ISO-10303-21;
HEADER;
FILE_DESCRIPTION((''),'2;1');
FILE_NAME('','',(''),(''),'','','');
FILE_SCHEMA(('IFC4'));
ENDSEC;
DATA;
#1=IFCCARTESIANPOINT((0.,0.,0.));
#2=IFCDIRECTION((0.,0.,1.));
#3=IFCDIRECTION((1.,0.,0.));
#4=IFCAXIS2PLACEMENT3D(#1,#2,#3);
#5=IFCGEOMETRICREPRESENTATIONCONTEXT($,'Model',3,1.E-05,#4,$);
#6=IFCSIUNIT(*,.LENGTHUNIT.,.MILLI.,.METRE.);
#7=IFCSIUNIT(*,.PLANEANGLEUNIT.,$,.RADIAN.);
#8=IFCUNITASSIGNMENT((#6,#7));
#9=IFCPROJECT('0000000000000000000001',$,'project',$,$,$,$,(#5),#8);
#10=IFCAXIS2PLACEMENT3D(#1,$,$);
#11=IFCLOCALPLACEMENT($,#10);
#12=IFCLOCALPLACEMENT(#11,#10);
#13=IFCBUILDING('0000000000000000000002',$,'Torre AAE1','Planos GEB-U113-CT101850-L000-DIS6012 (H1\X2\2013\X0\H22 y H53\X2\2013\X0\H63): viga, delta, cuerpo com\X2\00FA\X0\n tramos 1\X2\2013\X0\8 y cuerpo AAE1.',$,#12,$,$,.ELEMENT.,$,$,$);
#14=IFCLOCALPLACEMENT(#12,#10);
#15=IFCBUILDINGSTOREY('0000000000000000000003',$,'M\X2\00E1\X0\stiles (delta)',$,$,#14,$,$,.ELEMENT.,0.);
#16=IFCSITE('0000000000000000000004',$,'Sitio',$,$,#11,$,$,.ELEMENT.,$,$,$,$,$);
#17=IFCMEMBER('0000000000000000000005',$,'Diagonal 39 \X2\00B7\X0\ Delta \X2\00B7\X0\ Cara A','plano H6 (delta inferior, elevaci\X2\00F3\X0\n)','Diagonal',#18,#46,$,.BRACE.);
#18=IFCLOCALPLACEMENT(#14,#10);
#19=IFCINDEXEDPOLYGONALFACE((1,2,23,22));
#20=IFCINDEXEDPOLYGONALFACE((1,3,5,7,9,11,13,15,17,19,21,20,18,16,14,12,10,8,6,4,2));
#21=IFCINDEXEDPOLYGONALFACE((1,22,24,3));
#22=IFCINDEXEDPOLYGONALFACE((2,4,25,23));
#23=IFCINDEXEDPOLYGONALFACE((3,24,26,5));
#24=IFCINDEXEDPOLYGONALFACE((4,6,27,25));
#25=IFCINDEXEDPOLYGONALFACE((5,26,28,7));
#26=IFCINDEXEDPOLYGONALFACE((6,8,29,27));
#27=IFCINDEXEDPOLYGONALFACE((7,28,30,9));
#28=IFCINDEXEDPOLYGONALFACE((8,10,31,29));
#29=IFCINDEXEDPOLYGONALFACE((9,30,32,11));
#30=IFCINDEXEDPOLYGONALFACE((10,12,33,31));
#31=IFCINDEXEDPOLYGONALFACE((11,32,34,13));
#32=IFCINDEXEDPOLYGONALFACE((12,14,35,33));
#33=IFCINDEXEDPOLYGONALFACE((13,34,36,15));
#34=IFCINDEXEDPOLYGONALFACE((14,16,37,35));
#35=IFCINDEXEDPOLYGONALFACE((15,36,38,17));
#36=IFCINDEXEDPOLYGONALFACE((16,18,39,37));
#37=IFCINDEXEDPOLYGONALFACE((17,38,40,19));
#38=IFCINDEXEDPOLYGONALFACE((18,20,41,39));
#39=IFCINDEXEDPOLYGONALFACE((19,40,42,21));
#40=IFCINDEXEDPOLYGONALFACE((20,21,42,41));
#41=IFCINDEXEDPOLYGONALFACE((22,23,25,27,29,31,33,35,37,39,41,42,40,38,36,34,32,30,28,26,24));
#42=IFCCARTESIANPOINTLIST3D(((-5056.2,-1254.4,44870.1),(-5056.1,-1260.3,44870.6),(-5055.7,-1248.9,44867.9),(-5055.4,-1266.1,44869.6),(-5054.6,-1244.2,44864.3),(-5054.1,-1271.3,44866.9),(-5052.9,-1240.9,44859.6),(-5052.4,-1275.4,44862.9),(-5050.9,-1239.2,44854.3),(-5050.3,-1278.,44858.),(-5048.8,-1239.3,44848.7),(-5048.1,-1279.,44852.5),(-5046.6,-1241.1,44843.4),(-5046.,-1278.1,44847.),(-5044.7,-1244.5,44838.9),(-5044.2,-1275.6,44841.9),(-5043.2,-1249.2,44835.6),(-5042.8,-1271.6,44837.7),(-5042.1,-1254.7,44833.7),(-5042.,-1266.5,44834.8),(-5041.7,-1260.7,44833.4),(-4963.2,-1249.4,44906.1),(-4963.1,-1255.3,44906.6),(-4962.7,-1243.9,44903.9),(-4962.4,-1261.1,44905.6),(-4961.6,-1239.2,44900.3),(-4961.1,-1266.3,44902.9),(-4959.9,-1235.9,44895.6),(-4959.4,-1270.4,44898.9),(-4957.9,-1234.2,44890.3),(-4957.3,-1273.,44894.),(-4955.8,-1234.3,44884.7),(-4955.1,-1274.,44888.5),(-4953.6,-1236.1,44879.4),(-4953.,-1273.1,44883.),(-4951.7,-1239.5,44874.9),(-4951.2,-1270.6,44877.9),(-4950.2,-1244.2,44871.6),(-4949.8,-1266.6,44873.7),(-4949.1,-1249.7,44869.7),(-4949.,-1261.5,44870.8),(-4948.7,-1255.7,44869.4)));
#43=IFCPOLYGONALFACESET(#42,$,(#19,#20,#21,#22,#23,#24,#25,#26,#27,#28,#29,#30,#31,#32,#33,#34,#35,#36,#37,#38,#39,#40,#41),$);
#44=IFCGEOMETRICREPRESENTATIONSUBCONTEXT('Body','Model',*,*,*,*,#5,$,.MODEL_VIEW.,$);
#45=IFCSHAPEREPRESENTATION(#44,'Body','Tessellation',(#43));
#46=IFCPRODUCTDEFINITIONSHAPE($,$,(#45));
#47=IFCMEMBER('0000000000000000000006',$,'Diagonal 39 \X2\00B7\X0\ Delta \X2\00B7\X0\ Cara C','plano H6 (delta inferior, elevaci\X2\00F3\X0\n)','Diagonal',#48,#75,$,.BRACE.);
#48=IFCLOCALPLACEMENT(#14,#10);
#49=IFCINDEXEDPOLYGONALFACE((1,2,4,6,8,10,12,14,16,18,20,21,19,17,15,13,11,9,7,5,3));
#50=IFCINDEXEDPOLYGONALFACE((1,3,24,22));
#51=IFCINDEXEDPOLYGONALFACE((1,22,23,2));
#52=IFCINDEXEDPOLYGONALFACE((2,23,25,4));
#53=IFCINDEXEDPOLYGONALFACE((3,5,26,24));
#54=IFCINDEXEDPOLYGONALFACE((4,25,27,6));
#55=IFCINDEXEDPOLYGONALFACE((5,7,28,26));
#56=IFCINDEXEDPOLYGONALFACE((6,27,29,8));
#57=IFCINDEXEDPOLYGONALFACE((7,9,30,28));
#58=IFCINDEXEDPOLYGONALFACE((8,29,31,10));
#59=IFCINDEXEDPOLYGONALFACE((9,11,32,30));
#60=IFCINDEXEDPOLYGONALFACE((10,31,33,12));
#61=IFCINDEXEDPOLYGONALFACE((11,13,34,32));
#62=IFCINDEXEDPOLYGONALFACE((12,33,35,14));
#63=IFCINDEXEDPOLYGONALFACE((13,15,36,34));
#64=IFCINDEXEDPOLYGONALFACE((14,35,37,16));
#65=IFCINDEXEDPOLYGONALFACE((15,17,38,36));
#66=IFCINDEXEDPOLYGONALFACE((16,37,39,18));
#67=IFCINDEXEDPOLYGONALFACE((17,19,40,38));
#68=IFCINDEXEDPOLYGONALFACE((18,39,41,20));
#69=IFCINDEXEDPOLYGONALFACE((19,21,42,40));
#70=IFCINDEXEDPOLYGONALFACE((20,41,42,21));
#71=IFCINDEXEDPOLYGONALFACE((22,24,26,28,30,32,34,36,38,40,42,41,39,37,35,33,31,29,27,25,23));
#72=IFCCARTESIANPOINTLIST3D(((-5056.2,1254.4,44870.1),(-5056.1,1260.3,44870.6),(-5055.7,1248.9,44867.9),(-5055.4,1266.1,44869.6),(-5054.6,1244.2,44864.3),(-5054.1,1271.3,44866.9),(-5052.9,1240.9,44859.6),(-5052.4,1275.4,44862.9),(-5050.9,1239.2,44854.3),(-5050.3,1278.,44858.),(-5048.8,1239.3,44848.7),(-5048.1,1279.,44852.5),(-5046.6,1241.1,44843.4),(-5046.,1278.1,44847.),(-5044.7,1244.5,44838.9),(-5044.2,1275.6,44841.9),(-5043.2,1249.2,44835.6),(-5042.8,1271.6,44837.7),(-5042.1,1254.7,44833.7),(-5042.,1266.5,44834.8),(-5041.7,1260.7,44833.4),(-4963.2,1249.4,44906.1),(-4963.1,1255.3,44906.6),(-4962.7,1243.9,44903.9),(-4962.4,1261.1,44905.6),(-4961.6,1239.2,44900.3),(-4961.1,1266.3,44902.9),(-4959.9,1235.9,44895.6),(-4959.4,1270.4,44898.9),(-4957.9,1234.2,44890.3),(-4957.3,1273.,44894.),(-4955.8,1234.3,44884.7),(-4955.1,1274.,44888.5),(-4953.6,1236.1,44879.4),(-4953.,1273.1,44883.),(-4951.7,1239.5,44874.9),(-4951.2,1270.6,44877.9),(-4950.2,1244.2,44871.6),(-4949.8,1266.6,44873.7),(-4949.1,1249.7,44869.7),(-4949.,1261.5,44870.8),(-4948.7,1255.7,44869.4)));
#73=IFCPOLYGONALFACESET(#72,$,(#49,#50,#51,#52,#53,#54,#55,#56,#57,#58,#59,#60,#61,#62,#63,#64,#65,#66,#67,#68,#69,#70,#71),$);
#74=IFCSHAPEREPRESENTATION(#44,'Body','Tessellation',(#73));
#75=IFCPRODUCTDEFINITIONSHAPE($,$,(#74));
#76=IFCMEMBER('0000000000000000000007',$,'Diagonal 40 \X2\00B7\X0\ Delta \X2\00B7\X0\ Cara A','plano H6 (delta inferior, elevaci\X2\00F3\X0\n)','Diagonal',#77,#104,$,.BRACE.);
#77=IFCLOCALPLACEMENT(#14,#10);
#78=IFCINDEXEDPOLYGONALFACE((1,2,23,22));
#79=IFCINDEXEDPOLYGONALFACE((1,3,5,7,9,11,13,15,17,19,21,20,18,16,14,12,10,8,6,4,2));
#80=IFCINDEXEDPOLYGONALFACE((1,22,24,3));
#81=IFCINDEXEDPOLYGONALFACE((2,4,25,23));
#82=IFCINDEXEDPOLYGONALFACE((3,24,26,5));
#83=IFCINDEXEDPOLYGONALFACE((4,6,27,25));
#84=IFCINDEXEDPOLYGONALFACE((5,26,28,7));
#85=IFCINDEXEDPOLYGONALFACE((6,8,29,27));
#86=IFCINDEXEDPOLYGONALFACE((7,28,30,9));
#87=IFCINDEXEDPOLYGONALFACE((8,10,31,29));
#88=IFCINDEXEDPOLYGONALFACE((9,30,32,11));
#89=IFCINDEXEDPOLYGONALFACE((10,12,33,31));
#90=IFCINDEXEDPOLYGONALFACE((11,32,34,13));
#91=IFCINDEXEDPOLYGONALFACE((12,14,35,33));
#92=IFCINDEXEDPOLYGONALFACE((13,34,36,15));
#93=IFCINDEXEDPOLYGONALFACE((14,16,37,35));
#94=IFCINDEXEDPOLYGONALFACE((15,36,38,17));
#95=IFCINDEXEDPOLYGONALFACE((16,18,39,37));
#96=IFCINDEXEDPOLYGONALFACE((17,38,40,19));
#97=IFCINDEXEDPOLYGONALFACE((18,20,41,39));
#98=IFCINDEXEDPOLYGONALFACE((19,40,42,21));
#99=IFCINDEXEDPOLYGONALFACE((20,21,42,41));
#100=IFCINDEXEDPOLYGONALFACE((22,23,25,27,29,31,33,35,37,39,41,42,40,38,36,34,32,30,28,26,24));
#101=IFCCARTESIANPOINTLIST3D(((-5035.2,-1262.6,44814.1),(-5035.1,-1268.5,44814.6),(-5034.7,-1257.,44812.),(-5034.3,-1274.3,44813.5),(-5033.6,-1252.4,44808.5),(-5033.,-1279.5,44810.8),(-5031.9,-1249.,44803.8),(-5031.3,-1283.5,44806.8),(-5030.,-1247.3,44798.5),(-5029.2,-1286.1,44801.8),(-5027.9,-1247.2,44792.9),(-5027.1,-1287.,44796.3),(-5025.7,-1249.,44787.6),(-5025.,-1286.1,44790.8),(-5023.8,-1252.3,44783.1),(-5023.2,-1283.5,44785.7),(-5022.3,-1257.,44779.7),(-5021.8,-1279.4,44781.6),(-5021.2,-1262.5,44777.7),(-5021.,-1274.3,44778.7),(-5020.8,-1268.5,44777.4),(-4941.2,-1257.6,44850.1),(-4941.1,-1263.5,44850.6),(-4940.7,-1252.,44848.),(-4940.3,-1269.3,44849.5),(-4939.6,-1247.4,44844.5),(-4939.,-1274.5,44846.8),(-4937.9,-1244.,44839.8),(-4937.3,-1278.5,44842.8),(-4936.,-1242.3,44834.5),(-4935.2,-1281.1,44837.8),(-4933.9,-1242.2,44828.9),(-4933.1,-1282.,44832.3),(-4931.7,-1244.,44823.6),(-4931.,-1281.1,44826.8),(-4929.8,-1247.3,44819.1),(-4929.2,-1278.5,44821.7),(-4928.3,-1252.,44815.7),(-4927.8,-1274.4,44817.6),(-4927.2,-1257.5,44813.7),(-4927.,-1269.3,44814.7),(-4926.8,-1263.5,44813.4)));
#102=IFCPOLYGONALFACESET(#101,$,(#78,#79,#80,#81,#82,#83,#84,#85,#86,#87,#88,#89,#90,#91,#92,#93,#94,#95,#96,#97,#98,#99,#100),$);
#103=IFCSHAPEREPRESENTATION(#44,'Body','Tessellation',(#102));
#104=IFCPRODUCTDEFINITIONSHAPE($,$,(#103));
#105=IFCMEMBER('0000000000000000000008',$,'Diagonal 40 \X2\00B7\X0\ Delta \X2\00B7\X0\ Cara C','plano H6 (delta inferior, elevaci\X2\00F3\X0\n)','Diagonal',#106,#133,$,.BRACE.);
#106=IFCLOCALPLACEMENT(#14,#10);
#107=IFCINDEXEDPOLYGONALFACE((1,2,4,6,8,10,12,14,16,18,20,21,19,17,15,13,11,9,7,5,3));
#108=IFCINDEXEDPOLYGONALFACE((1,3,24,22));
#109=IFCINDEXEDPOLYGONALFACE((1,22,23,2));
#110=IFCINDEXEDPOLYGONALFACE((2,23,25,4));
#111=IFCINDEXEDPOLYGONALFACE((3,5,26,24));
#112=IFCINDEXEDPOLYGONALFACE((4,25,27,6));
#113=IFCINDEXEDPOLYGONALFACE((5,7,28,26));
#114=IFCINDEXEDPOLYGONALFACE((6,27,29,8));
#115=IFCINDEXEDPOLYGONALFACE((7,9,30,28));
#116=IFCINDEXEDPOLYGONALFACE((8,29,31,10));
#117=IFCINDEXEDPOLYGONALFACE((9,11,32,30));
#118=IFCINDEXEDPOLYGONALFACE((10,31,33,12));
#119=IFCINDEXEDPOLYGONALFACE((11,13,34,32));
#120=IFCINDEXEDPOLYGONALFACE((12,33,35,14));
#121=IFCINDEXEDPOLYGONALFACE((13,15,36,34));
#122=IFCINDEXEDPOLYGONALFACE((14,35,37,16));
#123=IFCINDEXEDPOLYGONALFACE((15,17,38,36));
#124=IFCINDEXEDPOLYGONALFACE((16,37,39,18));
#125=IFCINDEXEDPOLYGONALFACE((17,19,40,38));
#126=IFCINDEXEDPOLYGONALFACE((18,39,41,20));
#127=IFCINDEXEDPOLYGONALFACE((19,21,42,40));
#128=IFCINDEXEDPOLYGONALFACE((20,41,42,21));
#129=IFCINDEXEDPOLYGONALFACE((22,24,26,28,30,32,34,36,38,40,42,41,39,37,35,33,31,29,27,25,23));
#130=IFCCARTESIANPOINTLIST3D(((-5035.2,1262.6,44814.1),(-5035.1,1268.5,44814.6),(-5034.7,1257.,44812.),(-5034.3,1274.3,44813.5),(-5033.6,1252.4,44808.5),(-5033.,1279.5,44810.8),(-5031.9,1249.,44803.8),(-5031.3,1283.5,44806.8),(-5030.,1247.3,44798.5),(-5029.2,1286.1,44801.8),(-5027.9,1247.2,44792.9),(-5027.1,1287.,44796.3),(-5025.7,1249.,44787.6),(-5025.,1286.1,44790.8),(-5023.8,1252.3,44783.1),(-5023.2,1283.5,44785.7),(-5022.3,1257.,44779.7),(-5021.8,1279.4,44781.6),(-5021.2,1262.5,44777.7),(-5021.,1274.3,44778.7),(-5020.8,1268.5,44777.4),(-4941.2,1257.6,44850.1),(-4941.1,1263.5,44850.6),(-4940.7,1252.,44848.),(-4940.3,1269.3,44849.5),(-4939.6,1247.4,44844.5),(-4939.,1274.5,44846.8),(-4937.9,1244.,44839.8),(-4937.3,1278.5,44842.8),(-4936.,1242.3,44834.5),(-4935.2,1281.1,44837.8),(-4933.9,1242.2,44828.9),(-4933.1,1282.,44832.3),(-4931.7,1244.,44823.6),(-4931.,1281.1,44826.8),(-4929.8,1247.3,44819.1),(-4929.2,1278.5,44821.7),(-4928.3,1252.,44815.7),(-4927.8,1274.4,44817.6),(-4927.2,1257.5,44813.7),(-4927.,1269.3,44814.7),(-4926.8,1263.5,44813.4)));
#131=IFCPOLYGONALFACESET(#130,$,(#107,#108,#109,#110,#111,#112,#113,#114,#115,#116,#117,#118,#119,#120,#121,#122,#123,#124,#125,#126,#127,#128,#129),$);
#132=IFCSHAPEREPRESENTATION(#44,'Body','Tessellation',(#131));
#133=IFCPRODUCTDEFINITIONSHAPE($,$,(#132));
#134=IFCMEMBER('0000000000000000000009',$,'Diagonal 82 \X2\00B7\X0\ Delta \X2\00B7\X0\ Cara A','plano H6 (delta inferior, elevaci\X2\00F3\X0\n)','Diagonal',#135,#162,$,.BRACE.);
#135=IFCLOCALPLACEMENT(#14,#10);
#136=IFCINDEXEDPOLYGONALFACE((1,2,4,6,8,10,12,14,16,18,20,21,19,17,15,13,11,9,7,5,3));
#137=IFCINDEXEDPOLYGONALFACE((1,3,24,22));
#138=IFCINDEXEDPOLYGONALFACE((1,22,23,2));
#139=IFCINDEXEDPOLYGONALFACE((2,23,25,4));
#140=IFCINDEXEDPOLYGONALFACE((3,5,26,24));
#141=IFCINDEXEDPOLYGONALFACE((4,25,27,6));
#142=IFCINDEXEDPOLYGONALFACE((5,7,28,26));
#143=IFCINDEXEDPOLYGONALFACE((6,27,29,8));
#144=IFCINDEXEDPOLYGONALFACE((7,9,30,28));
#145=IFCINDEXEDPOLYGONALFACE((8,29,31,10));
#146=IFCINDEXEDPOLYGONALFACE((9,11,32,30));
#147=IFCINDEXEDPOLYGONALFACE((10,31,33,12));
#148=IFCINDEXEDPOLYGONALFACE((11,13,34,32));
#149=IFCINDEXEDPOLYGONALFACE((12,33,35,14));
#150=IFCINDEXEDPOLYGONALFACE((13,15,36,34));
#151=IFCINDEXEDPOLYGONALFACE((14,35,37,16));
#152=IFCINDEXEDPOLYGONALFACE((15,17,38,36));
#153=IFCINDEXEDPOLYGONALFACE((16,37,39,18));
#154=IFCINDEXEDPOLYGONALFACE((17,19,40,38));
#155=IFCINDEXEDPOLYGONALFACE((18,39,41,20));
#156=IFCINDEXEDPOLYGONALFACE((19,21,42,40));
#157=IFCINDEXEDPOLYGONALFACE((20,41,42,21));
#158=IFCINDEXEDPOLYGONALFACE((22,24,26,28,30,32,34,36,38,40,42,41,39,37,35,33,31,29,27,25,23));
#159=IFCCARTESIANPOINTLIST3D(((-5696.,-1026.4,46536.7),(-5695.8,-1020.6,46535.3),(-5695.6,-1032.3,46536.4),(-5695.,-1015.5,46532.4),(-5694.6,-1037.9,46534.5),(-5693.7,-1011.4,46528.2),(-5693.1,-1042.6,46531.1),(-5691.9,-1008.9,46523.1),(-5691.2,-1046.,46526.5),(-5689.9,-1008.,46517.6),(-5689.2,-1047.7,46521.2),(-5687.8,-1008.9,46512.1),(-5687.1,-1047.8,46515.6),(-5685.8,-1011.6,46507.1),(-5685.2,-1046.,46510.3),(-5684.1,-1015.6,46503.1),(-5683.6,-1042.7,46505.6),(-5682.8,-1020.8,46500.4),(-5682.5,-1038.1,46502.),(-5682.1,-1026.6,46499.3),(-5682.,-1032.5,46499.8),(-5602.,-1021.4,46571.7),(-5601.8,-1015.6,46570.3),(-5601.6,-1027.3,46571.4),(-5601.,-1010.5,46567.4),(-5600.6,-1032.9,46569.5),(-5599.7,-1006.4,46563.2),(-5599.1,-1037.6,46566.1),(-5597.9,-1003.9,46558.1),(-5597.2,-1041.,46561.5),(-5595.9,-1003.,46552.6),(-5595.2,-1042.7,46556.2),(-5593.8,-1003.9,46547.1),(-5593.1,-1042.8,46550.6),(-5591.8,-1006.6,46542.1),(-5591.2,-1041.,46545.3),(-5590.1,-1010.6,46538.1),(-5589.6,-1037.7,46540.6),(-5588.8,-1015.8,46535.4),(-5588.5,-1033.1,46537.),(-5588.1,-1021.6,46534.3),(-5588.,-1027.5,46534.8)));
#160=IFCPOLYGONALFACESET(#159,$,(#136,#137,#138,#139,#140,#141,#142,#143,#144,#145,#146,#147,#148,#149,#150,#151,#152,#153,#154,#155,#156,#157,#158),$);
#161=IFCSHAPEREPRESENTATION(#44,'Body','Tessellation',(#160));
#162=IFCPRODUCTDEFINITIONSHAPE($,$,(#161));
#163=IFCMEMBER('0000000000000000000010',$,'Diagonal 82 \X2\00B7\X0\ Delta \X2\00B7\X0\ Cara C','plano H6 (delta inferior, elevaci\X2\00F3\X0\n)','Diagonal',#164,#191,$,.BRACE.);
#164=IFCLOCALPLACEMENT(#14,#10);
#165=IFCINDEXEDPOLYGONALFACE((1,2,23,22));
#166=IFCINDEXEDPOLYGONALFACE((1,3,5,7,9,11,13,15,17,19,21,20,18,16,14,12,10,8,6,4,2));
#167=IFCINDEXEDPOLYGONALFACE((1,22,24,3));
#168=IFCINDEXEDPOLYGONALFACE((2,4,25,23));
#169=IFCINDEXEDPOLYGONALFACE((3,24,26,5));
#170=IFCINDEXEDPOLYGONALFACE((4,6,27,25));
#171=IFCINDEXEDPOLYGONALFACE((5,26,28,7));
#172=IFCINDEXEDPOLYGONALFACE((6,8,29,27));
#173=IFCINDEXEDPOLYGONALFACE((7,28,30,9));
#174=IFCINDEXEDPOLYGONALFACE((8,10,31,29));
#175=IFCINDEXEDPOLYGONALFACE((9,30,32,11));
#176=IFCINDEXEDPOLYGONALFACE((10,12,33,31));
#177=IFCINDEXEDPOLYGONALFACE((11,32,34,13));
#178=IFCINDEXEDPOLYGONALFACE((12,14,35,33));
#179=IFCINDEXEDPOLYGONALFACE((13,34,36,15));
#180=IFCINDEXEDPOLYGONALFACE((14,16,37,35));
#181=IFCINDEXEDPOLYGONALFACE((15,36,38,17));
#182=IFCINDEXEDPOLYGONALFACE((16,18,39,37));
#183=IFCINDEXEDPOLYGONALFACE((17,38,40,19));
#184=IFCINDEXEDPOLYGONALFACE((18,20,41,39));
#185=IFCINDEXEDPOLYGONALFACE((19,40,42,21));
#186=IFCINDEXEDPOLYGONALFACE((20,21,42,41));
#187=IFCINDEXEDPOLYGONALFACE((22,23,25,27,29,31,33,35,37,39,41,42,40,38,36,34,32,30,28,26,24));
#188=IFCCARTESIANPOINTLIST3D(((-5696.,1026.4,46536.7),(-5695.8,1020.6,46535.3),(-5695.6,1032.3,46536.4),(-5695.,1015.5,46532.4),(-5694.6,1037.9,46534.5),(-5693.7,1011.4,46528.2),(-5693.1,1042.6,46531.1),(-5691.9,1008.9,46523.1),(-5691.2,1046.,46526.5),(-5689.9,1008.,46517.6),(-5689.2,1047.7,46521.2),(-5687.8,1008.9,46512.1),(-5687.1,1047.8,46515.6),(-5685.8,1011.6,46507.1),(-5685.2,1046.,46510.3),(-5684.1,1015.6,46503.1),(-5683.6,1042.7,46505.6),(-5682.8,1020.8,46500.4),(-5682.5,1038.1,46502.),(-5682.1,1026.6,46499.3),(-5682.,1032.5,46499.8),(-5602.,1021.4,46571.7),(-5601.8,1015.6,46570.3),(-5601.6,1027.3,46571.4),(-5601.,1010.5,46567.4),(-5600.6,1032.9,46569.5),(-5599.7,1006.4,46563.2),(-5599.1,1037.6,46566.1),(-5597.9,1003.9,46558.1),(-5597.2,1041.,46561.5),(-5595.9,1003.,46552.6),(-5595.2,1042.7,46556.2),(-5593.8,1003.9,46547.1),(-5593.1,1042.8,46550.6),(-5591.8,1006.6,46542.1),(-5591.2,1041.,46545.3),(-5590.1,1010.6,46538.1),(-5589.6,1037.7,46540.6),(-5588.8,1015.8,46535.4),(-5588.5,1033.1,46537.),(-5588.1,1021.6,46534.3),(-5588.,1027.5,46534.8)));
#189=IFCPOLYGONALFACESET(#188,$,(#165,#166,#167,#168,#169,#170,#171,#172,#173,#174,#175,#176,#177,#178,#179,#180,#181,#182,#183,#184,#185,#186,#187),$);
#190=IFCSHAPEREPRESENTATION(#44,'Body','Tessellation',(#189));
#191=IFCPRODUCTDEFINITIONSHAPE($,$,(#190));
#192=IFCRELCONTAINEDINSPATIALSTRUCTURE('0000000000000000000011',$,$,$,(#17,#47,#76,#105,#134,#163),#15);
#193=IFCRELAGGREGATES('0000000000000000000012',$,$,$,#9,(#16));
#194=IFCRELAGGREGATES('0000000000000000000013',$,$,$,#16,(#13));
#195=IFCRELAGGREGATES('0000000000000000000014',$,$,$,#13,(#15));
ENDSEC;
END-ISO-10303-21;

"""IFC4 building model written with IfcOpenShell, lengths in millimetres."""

from ifc_helpers import new_model, si_unit, frame, origin, origin_with_axes, place, context, subcontext, project, spatial, circle, extrude, element, save


model = new_model("IFC4")

# Units and contexts
model_context = context("Model", 3, precision=1e-05, world=origin_with_axes())
body_context = subcontext(model_context, "Body", "Model", "MODEL_VIEW")
ifc_project = project(units=[si_unit("LENGTHUNIT", "METRE", prefix="MILLI"), si_unit("PLANEANGLEUNIT", "RADIAN")], contexts=[model_context])

# Site, building, storey
site_placement = place(None, origin())
site = spatial("IfcSite", under=ifc_project, at=site_placement, Name="Sitio", CompositionType="ELEMENT")
building_placement = place(site_placement, origin())
building = spatial("IfcBuilding", under=site, at=building_placement, Name="Torre AAE1", Description="Planos GEB-U113-CT101850-L000-DIS6012 (H1–H22 y H53–H63): viga, delta, cuerpo común tramos 1–8 y cuerpo AAE1.", CompositionType="ELEMENT")
storey_placement = place(building_placement, origin())
storey = spatial("IfcBuildingStorey", under=building, at=storey_placement, Name="Mástiles (delta)", CompositionType="ELEMENT", Elevation=0.0)

# Members
for number, where, z_axis, x_axis, name in (
    (1, (-4956.0, -1254.0, 44888.0), (-0.931398, -0.050075, -0.360541), (0.291234, 0.49166, -0.820642), "Diagonal 39 · Delta · Cara A"),
    (2, (-4956.0, 1254.0, 44888.0), (-0.931398, 0.050075, -0.360541), (0.291234, -0.49166, -0.820642), "Diagonal 39 · Delta · Cara C"),
):
    element("IfcMember", number, at=place(storey_placement, frame(where, z_axis=z_axis, x_axis=x_axis)), inside=storey, Name=name, Description="plano H6 (delta inferior, elevación)", ObjectType="Diagonal", PredefinedType="BRACE", context=body_context, shape_type="SweptSolid", body=[
        extrude(circle(Radius=20.0), None, (0.0, 0.0, 1.0), 99.8),
    ])
for number, where, z_axis, x_axis, name in (
    (3, (-4934.0, -1262.0, 44832.0), (-0.932707, -0.049612, -0.357207), (0.286229, 0.500713, -0.81692), "Diagonal 40 · Delta · Cara A"),
    (4, (-4934.0, 1262.0, 44832.0), (-0.932707, 0.049612, -0.357207), (0.286229, -0.500713, -0.81692), "Diagonal 40 · Delta · Cara C"),
):
    element("IfcMember", number, at=place(storey_placement, frame(where, z_axis=z_axis, x_axis=x_axis)), inside=storey, Name=name, Description="plano H6 (delta inferior, elevación)", ObjectType="Diagonal", PredefinedType="BRACE", context=body_context, shape_type="SweptSolid", body=[
        extrude(circle(Radius=20.0), None, (0.0, 0.0, 1.0), 100.8),
    ])
for number, where, z_axis, x_axis, name in (
    (5, (-5595.0, -1023.0, 46553.0), (-0.935984, -0.049786, -0.348505), (0.308647, 0.360098, -0.880379), "Diagonal 82 · Delta · Cara A"),
    (6, (-5595.0, 1023.0, 46553.0), (-0.935984, 0.049786, -0.348505), (0.308647, -0.360098, -0.880379), "Diagonal 82 · Delta · Cara C"),
):
    element("IfcMember", number, at=place(storey_placement, frame(where, z_axis=z_axis, x_axis=x_axis)), inside=storey, Name=name, Description="plano H6 (delta inferior, elevación)", ObjectType="Diagonal", PredefinedType="BRACE", context=body_context, shape_type="SweptSolid", body=[
        extrude(circle(Radius=20.0), None, (0.0, 0.0, 1.0), 100.4),
    ])

save(model, "model.ifc")
